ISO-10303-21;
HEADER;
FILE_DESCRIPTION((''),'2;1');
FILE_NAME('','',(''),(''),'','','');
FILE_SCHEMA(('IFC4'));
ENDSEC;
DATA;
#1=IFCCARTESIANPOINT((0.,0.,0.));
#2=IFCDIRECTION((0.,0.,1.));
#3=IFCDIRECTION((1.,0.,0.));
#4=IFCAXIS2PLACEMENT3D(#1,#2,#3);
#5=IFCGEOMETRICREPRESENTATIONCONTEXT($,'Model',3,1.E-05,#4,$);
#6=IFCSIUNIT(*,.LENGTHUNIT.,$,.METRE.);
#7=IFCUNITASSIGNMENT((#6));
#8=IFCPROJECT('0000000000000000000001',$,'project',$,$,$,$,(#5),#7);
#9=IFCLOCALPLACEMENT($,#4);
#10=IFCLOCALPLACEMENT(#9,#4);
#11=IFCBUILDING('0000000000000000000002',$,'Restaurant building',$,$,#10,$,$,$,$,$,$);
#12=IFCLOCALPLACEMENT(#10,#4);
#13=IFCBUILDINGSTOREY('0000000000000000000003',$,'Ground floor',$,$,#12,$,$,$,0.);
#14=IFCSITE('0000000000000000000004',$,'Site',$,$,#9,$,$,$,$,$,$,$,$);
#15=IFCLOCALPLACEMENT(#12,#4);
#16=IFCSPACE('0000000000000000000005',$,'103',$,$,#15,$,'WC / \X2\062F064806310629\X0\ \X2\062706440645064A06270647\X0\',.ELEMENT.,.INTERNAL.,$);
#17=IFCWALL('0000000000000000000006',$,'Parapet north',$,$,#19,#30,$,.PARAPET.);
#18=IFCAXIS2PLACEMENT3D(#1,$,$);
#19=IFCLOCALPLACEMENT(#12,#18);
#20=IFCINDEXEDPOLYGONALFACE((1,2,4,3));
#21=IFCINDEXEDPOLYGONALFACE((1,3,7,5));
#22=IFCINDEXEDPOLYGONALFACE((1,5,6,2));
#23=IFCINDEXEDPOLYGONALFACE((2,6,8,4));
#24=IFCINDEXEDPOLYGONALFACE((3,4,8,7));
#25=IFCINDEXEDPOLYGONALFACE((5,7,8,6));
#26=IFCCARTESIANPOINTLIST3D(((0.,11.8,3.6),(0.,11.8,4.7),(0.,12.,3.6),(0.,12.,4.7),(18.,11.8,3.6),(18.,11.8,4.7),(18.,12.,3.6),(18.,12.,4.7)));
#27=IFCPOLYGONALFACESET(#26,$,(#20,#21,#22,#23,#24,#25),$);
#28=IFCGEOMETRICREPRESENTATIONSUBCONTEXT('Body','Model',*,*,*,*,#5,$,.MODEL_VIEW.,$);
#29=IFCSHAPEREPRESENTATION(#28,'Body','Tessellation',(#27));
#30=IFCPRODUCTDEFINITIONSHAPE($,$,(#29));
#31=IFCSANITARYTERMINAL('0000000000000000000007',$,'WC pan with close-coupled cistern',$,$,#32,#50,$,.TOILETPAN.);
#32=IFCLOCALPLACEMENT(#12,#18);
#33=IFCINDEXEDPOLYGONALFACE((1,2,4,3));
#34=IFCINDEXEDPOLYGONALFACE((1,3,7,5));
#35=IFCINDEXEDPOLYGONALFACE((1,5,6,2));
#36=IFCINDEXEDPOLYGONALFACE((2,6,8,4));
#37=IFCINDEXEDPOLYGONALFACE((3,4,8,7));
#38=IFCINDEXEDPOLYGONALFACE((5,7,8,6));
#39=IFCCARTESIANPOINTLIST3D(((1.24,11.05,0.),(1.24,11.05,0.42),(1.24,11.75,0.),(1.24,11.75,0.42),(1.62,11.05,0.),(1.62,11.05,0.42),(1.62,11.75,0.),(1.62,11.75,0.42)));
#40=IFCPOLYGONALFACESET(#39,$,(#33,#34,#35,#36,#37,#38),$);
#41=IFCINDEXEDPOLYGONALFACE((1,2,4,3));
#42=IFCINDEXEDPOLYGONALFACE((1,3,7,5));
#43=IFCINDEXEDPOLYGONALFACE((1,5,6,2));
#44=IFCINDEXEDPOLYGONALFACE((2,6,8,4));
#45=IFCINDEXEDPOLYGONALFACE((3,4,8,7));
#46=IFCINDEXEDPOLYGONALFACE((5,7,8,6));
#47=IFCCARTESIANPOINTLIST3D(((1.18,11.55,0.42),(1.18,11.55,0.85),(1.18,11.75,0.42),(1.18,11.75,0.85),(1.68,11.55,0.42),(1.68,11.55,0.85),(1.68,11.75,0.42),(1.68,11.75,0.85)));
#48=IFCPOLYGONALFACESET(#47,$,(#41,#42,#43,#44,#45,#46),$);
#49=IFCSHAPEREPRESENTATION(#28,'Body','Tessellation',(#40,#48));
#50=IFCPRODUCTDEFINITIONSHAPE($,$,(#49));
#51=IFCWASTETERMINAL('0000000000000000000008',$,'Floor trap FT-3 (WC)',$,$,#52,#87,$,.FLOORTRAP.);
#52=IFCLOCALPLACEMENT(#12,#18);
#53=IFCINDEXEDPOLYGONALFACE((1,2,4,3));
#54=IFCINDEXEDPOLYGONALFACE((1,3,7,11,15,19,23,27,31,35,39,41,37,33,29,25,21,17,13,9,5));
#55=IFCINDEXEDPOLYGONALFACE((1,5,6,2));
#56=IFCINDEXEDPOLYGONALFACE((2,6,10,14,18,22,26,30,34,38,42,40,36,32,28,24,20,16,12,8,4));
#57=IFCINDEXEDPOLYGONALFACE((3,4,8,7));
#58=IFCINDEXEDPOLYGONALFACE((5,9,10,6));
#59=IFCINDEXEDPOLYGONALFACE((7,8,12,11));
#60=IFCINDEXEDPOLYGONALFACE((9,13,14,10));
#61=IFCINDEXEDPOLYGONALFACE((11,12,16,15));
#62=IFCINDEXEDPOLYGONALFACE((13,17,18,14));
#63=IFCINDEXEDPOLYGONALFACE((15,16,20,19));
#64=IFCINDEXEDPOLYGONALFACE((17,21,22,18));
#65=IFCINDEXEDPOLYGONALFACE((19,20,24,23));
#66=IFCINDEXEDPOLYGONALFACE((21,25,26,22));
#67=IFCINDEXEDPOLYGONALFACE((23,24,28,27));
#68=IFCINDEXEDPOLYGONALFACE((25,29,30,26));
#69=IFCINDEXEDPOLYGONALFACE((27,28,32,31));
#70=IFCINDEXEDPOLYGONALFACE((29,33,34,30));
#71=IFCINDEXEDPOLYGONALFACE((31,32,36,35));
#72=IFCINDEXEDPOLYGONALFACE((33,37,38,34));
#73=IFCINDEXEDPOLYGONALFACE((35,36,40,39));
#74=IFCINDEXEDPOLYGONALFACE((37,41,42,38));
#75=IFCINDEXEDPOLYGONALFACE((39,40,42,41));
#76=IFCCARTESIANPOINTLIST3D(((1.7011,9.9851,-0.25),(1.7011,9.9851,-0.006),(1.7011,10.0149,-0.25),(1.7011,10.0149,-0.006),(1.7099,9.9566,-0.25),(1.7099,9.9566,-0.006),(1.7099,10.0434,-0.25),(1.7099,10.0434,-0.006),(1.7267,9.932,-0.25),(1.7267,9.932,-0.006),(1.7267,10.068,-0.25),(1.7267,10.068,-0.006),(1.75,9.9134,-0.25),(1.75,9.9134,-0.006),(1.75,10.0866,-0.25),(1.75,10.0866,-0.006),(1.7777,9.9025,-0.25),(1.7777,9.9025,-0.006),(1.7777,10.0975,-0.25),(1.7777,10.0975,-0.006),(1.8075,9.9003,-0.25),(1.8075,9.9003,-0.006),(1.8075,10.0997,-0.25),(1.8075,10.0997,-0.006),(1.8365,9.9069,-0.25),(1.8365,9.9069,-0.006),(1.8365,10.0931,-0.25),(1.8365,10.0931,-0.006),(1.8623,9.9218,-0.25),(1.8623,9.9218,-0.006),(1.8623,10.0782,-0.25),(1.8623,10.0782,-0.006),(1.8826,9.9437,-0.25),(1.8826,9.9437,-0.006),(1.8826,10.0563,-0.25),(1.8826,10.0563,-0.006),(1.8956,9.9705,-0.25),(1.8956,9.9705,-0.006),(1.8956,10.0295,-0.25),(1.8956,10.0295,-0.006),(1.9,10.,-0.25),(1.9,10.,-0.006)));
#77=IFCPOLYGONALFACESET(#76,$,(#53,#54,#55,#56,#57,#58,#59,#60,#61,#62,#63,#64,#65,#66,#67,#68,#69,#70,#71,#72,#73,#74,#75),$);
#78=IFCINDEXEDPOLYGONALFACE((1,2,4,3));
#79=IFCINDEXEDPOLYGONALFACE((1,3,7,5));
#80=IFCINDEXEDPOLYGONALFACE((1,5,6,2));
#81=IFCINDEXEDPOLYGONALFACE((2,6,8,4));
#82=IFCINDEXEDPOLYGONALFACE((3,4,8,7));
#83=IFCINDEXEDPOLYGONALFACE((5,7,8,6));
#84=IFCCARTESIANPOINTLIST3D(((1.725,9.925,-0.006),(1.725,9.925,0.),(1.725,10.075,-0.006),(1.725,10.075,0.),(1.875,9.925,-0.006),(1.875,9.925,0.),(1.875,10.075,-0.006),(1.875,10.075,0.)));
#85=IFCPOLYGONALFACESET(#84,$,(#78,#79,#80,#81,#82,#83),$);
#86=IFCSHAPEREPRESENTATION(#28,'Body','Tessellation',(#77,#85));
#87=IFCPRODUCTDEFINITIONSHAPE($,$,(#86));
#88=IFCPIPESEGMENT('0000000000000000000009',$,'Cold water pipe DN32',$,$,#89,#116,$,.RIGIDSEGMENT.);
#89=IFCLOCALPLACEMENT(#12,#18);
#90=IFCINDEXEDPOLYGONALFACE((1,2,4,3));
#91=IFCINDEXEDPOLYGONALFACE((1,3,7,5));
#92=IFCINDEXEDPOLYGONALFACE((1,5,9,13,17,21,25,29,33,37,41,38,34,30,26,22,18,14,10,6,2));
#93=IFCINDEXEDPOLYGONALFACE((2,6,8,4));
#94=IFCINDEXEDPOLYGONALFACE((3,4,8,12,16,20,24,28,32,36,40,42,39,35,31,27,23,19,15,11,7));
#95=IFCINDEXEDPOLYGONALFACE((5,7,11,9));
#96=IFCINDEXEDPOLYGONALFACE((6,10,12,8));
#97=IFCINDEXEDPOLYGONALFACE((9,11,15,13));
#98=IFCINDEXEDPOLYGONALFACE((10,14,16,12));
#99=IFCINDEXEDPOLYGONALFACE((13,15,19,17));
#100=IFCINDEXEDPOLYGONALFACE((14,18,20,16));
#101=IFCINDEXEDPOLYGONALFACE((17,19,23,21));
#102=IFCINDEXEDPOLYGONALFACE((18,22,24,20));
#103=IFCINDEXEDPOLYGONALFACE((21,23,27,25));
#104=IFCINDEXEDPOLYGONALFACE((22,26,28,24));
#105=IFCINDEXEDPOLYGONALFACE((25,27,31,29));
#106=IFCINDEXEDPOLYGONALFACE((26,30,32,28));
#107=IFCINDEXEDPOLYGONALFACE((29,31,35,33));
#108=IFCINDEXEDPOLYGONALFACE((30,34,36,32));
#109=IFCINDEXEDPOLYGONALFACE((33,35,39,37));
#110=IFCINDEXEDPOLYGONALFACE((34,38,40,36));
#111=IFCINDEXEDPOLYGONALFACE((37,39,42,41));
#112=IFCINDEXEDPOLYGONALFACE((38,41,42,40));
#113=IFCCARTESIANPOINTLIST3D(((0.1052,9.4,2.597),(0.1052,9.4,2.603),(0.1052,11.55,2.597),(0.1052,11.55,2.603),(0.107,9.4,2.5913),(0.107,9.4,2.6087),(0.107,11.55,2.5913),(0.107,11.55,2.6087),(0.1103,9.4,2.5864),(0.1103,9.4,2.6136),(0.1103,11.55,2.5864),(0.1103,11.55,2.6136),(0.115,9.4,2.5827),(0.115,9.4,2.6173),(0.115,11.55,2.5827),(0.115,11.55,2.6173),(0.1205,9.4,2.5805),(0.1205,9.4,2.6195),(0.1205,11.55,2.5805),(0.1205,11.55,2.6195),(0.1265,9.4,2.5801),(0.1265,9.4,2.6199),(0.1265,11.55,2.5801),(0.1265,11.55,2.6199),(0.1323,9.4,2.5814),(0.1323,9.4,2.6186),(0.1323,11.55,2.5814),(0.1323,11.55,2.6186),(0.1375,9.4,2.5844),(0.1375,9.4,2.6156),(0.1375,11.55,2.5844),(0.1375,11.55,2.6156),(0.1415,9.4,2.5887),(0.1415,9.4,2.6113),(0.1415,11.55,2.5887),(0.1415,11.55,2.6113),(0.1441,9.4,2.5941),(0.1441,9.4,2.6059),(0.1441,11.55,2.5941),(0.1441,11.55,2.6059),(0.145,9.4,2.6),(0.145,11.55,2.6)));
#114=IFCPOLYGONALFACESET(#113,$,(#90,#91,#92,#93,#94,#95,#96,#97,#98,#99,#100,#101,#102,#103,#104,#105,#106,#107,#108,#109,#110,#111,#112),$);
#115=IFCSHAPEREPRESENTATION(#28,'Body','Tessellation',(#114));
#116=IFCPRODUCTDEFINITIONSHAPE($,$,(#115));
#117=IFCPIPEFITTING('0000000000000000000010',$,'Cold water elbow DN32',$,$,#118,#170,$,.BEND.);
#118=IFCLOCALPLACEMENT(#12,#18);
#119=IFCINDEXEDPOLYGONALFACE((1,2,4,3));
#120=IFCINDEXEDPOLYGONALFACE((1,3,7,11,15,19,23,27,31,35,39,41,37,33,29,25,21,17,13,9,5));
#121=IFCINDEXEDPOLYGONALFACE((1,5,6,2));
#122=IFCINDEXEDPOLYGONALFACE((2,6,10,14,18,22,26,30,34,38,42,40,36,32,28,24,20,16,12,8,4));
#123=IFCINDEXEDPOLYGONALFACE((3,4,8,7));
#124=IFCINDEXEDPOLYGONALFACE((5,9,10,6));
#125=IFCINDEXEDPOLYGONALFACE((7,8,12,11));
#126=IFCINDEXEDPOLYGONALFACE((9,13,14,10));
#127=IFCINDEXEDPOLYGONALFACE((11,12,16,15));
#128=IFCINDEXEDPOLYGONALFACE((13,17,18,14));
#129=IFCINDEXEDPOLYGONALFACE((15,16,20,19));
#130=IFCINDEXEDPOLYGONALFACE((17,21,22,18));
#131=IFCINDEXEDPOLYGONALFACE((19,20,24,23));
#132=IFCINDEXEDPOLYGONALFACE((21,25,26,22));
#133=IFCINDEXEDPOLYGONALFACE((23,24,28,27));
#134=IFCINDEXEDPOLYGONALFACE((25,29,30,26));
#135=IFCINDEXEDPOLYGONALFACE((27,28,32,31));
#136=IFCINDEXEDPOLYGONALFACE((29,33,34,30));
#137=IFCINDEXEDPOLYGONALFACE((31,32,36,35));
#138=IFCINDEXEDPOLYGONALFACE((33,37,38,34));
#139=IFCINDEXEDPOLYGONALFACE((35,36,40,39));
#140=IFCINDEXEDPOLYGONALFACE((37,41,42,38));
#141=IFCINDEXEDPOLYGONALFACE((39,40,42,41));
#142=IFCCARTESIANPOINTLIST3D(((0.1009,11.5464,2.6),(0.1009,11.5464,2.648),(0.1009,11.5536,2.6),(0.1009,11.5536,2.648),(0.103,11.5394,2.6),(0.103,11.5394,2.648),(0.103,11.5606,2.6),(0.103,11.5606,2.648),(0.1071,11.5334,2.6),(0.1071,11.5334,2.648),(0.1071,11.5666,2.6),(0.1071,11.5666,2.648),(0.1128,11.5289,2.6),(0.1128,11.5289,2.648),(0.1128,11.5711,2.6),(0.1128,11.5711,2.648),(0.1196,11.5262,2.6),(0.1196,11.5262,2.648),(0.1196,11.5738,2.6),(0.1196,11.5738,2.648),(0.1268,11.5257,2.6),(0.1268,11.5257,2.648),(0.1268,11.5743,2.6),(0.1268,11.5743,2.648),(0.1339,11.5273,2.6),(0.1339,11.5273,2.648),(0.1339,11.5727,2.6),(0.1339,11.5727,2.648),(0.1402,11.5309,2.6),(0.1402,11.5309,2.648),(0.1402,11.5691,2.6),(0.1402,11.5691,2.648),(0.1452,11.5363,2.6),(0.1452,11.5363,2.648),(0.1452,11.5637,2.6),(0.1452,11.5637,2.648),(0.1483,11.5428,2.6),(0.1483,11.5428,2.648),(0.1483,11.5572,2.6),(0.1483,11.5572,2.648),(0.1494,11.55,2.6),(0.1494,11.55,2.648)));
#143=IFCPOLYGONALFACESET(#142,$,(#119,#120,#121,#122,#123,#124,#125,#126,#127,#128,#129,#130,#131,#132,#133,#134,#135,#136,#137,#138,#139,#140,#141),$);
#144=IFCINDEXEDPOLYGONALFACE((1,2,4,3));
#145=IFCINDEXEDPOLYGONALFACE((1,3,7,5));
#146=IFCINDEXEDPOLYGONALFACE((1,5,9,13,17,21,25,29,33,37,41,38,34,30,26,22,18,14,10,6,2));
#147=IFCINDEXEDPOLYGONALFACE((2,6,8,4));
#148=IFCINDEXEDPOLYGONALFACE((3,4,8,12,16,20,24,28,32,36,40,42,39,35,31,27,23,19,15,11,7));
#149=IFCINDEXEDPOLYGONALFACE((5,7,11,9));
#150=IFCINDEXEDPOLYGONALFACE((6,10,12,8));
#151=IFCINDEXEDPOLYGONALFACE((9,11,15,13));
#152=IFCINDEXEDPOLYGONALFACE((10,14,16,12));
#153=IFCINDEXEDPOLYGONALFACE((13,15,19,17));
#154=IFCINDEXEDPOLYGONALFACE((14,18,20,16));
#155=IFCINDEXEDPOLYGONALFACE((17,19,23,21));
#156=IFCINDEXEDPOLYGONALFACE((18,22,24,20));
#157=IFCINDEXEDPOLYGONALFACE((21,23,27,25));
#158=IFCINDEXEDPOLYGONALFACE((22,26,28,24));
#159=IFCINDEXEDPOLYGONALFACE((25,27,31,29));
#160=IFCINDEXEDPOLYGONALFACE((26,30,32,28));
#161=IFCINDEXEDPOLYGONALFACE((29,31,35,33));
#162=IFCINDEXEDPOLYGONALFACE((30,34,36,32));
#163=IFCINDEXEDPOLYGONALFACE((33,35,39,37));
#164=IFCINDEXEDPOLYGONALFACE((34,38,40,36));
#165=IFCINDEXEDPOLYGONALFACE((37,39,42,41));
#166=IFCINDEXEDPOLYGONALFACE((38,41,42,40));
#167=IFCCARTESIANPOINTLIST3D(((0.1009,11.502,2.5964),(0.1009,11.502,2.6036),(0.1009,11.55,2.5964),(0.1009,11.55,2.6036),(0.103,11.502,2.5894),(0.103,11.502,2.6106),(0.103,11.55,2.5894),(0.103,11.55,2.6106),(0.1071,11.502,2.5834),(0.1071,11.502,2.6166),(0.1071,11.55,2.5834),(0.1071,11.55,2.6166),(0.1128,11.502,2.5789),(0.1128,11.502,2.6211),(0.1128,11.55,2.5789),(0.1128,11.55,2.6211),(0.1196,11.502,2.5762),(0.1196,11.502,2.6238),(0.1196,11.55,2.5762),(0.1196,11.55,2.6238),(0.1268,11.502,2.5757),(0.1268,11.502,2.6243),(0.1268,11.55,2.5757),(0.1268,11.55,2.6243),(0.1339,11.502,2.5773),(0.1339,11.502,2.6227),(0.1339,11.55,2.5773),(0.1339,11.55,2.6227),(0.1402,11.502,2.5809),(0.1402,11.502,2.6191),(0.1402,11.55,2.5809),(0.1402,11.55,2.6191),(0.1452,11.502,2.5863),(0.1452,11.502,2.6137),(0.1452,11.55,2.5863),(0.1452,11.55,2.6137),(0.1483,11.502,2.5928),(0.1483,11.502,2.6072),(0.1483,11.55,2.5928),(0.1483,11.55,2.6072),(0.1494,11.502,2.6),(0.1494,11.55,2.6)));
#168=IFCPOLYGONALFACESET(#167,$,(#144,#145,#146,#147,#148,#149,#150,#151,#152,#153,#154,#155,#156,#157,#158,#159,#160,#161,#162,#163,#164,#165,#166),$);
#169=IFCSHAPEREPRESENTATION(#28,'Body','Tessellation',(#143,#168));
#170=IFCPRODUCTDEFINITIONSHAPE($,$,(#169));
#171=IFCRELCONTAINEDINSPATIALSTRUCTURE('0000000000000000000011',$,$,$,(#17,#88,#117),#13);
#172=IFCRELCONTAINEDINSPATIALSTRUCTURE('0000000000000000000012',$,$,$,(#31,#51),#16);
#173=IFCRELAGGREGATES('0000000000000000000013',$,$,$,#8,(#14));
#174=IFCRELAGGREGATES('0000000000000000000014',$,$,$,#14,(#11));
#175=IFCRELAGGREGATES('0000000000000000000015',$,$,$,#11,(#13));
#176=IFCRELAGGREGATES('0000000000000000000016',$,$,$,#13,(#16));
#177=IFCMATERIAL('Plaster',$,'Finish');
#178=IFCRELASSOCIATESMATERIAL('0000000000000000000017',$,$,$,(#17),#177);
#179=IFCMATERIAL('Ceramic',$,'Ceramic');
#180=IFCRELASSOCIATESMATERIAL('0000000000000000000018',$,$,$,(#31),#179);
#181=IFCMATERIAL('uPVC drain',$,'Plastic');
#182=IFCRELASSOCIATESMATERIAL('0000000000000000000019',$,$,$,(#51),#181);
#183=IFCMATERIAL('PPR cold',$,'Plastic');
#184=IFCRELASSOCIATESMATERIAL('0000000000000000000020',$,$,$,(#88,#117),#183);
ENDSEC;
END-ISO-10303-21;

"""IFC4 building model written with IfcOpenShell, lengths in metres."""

from ifc_helpers import new_model, si_unit, frame, origin, origin_with_axes, origin_2d, place, context, subcontext, project, spatial, rectangle, circle, extrude, material, element, save


model = new_model("IFC4")

# Units and contexts
model_context = context("Model", 3, precision=1e-05, world=origin_with_axes())
body_context = subcontext(model_context, "Body", "Model", "MODEL_VIEW")
ifc_project = project(units=[si_unit("LENGTHUNIT", "METRE")], contexts=[model_context])

# Site, building, storey
site_placement = place(None, origin_with_axes())
site = spatial("IfcSite", under=ifc_project, at=site_placement, Name="Site")
building_placement = place(site_placement, origin_with_axes())
building = spatial("IfcBuilding", under=site, at=building_placement, Name="Restaurant building")
storey_placement = place(building_placement, origin_with_axes())
storey = spatial("IfcBuildingStorey", under=building, at=storey_placement, Name="Ground floor", Elevation=0.0)

# Shared definitions
ifc_material_1 = material(Name="Plaster", Category="Finish")

# Wall
wall_1_placement = place(storey_placement, frame((0.0, 11.9, 0.0)))
element("IfcWall", 1, at=wall_1_placement, inside=storey, material=ifc_material_1, Name="Parapet north", PredefinedType="PARAPET", context=body_context, shape_type="SweptSolid", body=[
    extrude(rectangle(XDim=18.0, YDim=0.2, at=origin_2d()), frame((9.0, 0.0, 3.6)), (0.0, 0.0, 1.0), 1.1),
])

# Shared definitions
space_placement = place(storey_placement, origin_with_axes())
space = spatial("IfcSpace", under=storey, at=space_placement, Name="103", LongName="WC / دورة المياه", CompositionType="ELEMENT", PredefinedType="INTERNAL")

# Sanitary terminal
ifc_material_2 = material(Name="Ceramic", Category="Ceramic")
sanitary_terminal_placement = place(storey_placement, frame((1.24, 11.05, 0.0)))
element("IfcSanitaryTerminal", 2, at=sanitary_terminal_placement, inside=space, material=ifc_material_2, Name="WC pan with close-coupled cistern", PredefinedType="TOILETPAN", context=body_context, shape_type="SweptSolid", body=[
    extrude(rectangle(XDim=0.38, YDim=0.7, at=origin_2d()), frame((0.19, 0.35, 0.0)), (0.0, 0.0, 1.0), 0.42),
    extrude(rectangle(XDim=0.5, YDim=0.2, at=origin_2d()), frame((0.19, 0.6, 0.42)), (0.0, 0.0, 1.0), 0.43),
])

# Waste terminal
ifc_material_3 = material(Name="uPVC drain", Category="Plastic")
waste_terminal_placement = place(storey_placement, frame((1.8, 10.0, 0.0)))
element("IfcWasteTerminal", 3, at=waste_terminal_placement, inside=space, material=ifc_material_3, Name="Floor trap FT-3 (WC)", PredefinedType="FLOORTRAP", context=body_context, shape_type="SweptSolid", body=[
    extrude(circle(Radius=0.1, at=origin_2d()), frame((0.0, 0.0, -0.25)), (0.0, 0.0, 1.0), 0.244),
    extrude(rectangle(XDim=0.15, YDim=0.15, at=origin_2d()), frame((0.0, 0.0, -0.006)), (0.0, 0.0, 1.0), 0.006),
])

# Pipe segment
ifc_material_4 = material(Name="PPR cold", Category="Plastic")
pipe_segment_1_placement = place(storey_placement, frame((0.125, 11.55, 2.6)))
element("IfcPipeSegment", 4, at=pipe_segment_1_placement, inside=storey, material=ifc_material_4, Name="Cold water pipe DN32", PredefinedType="RIGIDSEGMENT", context=body_context, shape_type="SweptSolid", body=[
    extrude(circle(Radius=0.02, at=origin_2d()), frame((0.0, 0.0, 0.0), z_axis=(0.0, -1.0, 0.0), x_axis=(1.0, 0.0, 0.0)), (0.0, 0.0, 1.0), 2.15),
])

# Pipe fitting
pipe_fitting_1_placement = place(storey_placement, frame((0.125, 11.55, 2.6)))
element("IfcPipeFitting", 5, at=pipe_fitting_1_placement, inside=storey, material=ifc_material_4, Name="Cold water elbow DN32", PredefinedType="BEND", context=body_context, shape_type="SweptSolid", body=[
    extrude(circle(Radius=0.0244, at=origin_2d()), origin(), (0.0, 0.0, 1.0), 0.048),
    extrude(circle(Radius=0.0244, at=origin_2d()), frame((0.0, 0.0, 0.0), z_axis=(0.0, -1.0, 0.0), x_axis=(1.0, 0.0, 0.0)), (0.0, 0.0, 1.0), 0.048),
])

save(model, "model.ifc")
